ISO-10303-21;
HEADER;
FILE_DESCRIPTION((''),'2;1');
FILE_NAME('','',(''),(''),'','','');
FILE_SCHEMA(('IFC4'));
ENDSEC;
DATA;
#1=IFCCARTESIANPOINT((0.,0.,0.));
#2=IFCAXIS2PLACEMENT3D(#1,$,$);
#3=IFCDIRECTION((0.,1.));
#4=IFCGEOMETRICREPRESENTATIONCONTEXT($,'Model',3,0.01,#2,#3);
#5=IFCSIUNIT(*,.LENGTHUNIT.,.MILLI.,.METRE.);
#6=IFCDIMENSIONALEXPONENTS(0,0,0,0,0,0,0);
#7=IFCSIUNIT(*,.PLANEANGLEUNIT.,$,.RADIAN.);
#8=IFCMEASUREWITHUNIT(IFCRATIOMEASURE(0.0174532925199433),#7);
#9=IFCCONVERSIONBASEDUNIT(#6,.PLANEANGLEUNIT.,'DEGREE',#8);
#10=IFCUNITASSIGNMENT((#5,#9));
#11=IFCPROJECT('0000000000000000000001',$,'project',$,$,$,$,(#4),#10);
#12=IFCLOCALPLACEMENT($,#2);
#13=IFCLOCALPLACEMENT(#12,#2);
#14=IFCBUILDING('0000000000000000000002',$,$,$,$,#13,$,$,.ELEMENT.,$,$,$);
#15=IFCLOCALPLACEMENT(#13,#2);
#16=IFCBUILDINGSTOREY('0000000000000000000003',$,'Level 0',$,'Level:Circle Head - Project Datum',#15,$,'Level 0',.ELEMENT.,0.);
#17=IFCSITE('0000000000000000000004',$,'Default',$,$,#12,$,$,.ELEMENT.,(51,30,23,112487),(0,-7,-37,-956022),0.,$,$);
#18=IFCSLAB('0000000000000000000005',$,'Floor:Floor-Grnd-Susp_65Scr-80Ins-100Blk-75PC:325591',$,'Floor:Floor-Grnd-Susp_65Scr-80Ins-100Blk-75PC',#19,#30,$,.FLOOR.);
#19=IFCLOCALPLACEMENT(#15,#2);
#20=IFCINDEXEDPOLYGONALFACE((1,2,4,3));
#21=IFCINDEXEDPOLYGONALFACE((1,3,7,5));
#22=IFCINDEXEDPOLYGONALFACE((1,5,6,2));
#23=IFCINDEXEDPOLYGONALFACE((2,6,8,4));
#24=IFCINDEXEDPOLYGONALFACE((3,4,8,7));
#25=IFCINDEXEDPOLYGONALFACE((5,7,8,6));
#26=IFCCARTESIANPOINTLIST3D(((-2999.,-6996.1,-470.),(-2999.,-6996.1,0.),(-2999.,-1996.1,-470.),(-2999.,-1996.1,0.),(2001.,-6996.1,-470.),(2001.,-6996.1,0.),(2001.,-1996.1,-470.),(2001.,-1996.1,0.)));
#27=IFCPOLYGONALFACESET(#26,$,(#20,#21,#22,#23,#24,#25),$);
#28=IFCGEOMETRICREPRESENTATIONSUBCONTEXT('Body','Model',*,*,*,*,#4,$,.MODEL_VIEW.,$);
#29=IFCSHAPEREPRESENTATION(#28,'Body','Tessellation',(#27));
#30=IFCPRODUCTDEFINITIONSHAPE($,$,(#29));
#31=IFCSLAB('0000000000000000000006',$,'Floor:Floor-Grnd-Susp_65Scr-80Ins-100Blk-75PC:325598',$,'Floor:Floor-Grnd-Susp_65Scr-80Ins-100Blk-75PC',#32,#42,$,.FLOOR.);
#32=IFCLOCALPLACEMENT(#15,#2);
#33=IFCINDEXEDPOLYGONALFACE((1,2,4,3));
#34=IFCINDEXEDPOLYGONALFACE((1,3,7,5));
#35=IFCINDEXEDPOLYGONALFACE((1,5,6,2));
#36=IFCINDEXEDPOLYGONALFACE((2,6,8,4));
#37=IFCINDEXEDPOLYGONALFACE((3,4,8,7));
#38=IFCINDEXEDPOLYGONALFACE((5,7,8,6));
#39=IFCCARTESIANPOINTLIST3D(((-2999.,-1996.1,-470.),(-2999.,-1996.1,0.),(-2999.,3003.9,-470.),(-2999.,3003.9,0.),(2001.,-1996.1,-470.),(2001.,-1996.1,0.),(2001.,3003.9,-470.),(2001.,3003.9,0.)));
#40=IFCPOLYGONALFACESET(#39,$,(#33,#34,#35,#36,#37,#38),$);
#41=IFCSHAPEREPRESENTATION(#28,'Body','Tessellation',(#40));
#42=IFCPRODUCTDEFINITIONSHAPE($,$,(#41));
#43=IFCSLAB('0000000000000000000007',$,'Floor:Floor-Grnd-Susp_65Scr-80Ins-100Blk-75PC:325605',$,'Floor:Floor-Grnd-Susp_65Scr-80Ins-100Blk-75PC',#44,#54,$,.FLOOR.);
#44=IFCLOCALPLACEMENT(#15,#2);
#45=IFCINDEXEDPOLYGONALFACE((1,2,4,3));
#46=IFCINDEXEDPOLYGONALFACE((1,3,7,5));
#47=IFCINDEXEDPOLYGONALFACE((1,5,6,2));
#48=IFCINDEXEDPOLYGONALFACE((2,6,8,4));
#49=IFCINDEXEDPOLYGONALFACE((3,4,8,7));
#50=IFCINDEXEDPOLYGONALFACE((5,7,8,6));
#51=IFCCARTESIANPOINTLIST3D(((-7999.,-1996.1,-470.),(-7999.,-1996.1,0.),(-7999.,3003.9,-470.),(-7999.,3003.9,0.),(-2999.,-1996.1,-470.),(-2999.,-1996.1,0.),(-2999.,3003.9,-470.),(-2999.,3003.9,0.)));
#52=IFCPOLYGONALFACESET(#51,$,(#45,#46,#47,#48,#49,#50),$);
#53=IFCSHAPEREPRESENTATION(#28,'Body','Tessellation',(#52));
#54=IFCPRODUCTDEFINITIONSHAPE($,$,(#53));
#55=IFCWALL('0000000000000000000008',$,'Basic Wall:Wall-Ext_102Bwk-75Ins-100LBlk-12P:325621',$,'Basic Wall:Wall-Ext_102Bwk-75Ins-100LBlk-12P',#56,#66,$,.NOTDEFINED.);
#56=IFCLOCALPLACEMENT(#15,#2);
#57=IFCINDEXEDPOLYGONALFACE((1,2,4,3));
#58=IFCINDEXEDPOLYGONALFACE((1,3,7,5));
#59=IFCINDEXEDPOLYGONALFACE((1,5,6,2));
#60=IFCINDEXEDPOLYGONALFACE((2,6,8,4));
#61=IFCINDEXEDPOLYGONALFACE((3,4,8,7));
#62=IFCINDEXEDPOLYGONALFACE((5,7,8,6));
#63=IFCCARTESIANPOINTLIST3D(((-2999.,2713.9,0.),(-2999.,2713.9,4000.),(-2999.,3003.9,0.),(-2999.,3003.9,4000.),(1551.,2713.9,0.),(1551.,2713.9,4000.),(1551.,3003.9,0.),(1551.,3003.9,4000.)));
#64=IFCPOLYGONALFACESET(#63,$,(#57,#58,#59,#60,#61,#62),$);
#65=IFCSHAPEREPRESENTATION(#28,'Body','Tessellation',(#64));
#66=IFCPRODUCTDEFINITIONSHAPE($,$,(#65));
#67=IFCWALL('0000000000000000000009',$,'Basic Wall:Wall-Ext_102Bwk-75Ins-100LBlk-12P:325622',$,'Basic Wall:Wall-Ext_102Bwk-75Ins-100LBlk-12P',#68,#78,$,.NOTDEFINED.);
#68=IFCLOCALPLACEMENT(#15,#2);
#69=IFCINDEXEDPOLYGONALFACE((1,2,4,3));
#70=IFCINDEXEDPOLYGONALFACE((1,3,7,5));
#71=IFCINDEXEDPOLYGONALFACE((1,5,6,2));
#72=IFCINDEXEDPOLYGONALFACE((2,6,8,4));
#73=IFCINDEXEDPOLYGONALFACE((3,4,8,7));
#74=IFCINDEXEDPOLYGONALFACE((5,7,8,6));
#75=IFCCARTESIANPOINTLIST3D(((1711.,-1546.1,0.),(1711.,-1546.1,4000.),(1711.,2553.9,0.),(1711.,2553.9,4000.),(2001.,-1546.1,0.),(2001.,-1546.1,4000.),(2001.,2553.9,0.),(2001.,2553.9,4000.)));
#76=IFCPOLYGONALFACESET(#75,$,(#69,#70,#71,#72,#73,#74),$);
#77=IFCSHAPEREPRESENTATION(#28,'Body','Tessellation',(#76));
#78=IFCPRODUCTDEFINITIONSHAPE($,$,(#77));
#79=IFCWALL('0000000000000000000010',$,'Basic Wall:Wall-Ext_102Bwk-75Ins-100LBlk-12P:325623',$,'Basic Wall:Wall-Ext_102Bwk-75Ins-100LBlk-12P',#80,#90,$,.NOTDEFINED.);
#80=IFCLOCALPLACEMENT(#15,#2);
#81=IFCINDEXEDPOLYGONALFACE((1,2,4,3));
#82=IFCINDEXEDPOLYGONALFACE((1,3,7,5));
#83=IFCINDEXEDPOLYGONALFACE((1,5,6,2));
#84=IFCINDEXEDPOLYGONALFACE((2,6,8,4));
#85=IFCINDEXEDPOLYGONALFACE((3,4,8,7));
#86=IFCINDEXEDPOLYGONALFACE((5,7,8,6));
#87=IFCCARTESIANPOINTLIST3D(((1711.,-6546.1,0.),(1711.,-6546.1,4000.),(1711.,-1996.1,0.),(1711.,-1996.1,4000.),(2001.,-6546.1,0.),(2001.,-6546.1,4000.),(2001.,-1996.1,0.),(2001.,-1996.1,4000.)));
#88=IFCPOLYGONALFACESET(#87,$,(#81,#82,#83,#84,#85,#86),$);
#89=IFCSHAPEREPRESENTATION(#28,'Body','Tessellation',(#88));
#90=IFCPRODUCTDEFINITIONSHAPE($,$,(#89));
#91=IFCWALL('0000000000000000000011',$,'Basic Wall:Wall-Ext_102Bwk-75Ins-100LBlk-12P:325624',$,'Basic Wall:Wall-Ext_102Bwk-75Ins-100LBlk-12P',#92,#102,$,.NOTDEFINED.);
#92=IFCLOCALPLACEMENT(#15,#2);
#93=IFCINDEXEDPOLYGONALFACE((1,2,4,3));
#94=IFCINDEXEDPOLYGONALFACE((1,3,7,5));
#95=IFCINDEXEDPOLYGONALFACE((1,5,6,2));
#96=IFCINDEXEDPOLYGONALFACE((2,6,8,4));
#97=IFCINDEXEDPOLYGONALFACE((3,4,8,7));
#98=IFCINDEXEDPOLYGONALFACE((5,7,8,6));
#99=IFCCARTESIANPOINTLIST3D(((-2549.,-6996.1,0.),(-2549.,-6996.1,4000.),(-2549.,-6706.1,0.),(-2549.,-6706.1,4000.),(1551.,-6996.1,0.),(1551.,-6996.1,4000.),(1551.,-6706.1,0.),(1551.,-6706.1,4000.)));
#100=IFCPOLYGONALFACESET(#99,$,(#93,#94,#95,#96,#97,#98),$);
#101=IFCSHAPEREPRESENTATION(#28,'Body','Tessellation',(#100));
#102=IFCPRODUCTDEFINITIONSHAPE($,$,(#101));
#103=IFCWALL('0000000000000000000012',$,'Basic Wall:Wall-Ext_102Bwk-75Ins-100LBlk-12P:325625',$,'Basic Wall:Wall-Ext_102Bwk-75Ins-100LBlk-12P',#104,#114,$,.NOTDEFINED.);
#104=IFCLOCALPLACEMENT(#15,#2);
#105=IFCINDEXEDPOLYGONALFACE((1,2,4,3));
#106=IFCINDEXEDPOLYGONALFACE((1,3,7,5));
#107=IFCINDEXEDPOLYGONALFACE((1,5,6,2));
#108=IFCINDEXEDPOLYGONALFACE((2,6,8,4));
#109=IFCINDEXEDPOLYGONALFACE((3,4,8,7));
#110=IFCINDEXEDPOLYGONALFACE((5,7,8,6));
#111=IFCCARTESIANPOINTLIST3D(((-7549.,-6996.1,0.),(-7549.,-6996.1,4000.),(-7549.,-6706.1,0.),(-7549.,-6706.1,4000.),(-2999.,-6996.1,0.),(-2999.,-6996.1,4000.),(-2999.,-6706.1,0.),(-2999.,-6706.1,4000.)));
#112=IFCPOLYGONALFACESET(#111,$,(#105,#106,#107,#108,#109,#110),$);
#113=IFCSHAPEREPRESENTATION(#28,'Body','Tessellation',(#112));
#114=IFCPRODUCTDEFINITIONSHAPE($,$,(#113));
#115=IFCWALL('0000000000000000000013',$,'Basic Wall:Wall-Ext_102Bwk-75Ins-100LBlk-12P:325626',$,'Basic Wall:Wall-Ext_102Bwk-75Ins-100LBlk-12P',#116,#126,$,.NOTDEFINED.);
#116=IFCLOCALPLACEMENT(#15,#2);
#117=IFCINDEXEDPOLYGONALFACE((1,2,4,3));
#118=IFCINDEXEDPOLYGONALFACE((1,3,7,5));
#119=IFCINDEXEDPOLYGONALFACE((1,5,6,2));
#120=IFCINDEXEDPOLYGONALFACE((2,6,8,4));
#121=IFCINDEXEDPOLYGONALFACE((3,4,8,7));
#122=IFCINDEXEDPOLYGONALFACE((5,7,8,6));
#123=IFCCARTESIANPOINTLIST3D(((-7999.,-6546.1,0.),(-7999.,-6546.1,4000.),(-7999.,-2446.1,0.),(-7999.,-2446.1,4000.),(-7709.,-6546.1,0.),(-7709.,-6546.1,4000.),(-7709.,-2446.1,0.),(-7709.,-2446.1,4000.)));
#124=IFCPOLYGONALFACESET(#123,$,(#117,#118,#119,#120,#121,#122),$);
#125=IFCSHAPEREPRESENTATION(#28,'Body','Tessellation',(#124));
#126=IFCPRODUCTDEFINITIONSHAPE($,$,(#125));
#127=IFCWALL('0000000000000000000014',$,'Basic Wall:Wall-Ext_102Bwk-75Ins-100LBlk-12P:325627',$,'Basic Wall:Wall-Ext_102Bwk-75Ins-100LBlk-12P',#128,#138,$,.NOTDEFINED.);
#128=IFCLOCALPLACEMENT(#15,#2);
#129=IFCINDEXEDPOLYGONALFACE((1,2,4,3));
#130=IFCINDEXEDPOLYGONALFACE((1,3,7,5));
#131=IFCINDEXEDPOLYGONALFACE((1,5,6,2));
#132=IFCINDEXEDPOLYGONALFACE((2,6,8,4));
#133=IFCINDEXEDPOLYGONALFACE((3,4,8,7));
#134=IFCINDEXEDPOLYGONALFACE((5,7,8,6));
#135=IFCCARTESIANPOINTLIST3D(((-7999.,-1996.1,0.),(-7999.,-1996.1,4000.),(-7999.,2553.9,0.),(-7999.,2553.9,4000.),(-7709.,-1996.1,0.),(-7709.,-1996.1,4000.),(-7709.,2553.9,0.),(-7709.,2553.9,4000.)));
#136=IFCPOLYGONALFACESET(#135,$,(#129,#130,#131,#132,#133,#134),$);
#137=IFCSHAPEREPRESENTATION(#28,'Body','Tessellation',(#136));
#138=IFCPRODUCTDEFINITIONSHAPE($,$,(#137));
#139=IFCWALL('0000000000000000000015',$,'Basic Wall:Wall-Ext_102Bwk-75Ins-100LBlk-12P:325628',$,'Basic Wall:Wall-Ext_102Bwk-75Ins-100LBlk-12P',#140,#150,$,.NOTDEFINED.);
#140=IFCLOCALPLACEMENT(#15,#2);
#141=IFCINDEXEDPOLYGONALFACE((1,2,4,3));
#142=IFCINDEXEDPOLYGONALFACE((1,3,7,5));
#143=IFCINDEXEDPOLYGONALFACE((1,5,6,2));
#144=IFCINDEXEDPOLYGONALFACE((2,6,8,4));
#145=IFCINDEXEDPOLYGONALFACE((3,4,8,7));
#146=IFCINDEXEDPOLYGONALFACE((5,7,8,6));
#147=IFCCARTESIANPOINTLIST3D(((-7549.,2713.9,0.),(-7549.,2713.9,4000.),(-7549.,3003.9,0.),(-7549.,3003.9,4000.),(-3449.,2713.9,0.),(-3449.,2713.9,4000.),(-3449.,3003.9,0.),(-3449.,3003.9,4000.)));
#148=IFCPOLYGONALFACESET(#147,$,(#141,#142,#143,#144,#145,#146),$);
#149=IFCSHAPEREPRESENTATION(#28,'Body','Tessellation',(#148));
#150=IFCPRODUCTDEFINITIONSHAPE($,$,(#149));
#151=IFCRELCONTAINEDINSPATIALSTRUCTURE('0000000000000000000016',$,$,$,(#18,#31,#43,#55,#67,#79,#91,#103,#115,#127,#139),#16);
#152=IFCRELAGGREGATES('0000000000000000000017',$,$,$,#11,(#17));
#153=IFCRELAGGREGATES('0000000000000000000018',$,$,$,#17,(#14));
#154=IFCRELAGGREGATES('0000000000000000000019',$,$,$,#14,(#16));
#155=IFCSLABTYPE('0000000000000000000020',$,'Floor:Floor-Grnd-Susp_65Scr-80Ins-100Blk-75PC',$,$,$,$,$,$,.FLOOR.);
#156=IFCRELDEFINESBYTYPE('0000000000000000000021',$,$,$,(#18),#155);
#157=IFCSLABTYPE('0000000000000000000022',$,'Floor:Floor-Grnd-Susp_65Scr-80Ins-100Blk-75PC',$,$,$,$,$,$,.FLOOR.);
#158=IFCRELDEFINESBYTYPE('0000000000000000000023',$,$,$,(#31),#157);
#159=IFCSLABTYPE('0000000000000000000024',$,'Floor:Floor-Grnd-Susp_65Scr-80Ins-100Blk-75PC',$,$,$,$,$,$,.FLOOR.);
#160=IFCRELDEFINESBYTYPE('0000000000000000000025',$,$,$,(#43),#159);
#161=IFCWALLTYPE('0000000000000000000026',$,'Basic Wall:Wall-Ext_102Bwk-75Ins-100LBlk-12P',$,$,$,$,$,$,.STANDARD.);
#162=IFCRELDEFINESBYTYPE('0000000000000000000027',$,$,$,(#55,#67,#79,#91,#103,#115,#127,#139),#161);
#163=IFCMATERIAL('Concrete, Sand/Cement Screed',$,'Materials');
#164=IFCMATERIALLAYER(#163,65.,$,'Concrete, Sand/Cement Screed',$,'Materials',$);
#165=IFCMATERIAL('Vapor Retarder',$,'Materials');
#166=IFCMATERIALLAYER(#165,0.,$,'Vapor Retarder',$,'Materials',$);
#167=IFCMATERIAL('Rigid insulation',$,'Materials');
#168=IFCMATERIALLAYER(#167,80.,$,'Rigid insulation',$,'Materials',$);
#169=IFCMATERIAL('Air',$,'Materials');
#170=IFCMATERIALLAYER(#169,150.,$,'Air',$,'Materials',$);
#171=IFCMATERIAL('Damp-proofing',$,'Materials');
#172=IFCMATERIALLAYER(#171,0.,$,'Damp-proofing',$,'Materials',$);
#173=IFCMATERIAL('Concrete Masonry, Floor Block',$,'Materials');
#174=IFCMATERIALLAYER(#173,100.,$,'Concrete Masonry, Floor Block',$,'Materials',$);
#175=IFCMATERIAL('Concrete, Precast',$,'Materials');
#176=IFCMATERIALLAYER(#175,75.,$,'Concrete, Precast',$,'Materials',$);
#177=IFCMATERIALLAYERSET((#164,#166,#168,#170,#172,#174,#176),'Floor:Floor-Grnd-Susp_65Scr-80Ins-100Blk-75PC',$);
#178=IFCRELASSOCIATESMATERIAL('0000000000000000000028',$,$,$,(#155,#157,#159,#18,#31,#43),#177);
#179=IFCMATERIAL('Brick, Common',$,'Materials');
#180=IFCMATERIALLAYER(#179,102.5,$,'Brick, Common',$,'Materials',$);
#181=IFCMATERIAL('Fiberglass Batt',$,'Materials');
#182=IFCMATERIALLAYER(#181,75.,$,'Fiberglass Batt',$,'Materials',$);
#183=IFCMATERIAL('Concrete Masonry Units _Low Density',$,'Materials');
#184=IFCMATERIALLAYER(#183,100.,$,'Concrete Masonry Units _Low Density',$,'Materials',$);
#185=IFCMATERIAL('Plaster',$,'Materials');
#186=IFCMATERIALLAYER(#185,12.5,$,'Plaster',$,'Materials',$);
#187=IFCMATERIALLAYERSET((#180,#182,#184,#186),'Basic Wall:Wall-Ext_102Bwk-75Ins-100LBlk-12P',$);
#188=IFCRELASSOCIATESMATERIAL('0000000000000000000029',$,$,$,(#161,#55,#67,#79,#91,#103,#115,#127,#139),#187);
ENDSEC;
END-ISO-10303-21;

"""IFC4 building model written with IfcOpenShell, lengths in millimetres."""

from ifc_helpers import new_model, entity, si_unit, converted_unit, direction, frame, frame_2d, origin, origin_2d_with_axis, place, context, subcontext, project, spatial, rectangle, extrude, material, layer, layer_set, layer_usage, type_object, element, save


model = new_model("IFC4")

# Units and contexts
model_context = context("Model", 3, precision=0.01, world=origin(), true_north=direction((0.0, 1.0)))
body_context = subcontext(model_context, "Body", "Model", "MODEL_VIEW")
ifc_project = project(units=[si_unit("LENGTHUNIT", "METRE", prefix="MILLI"), converted_unit("PLANEANGLEUNIT", "DEGREE", entity("IfcRatioMeasure", 0.0174532925199433), si_unit("PLANEANGLEUNIT", "RADIAN"), dimensions=[0, 0, 0, 0, 0, 0, 0])], contexts=[model_context])

# Site, building, storey
site_placement = place(None, origin())
site = spatial("IfcSite", under=ifc_project, at=site_placement, Name="Default", CompositionType="ELEMENT", RefLatitude=(51, 30, 23, 112487), RefLongitude=(0, -7, -37, -956022), RefElevation=0.0)
building_placement = place(site_placement, origin())
building = spatial("IfcBuilding", under=site, at=building_placement, CompositionType="ELEMENT")
storey_placement = place(building_placement, origin())
storey = spatial("IfcBuildingStorey", under=building, at=storey_placement, Name="Level 0", ObjectType="Level:Circle Head - Project Datum", LongName="Level 0", CompositionType="ELEMENT", Elevation=0.0)

# Slabs
ifc_material_1 = material(Name="Concrete, Sand/Cement Screed", Category="Materials")
ifc_layer_1 = layer(ifc_material_1, 65.0, Name="Concrete, Sand/Cement Screed", Category="Materials")
ifc_material_2 = material(Name="Vapor Retarder", Category="Materials")
ifc_layer_2 = layer(ifc_material_2, 0.0, Name="Vapor Retarder", Category="Materials")
ifc_material_3 = material(Name="Rigid insulation", Category="Materials")
ifc_layer_3 = layer(ifc_material_3, 80.0, Name="Rigid insulation", Category="Materials")
ifc_material_4 = material(Name="Air", Category="Materials")
ifc_layer_4 = layer(ifc_material_4, 150.0, Name="Air", Category="Materials")
ifc_material_5 = material(Name="Damp-proofing", Category="Materials")
ifc_layer_5 = layer(ifc_material_5, 0.0, Name="Damp-proofing", Category="Materials")
ifc_material_6 = material(Name="Concrete Masonry, Floor Block", Category="Materials")
ifc_layer_6 = layer(ifc_material_6, 100.0, Name="Concrete Masonry, Floor Block", Category="Materials")
ifc_material_7 = material(Name="Concrete, Precast", Category="Materials")
ifc_layer_7 = layer(ifc_material_7, 75.0, Name="Concrete, Precast", Category="Materials")
ifc_layer_set_1 = layer_set([ifc_layer_1, ifc_layer_2, ifc_layer_3, ifc_layer_4, ifc_layer_5, ifc_layer_6, ifc_layer_7], Name="Floor:Floor-Grnd-Susp_65Scr-80Ins-100Blk-75PC")
ifc_layer_usage_1 = layer_usage(ifc_layer_set_1, "AXIS3", "POSITIVE", 0.0)
slab_type_1 = type_object("IfcSlabType", Name="Floor:Floor-Grnd-Susp_65Scr-80Ins-100Blk-75PC", PredefinedType="FLOOR", material=ifc_layer_set_1)
slab_1_placement = place(storey_placement, origin())
element("IfcSlab", 1, at=slab_1_placement, inside=storey, type_object=slab_type_1, material=ifc_layer_usage_1, Name="Floor:Floor-Grnd-Susp_65Scr-80Ins-100Blk-75PC:325591", ObjectType="Floor:Floor-Grnd-Susp_65Scr-80Ins-100Blk-75PC", PredefinedType="FLOOR", context=body_context, shape_type="SweptSolid", body=[
    extrude(rectangle(XDim=5000.0, YDim=5000.0, at=frame_2d((0.0, 0.0), x_axis=(1.0, 0.0))), frame((-499.0, -4496.1, 0.0), z_axis=(0.0, 0.0, -1.0), x_axis=(0.0, 1.0, 0.0)), (0.0, 0.0, 1.0), 470.0),
])
ifc_layer_usage_2 = layer_usage(ifc_layer_set_1, "AXIS3", "POSITIVE", 0.0)
slab_type_2 = type_object("IfcSlabType", Name="Floor:Floor-Grnd-Susp_65Scr-80Ins-100Blk-75PC", PredefinedType="FLOOR", material=ifc_layer_set_1)
slab_2_placement = place(storey_placement, origin())
element("IfcSlab", 2, at=slab_2_placement, inside=storey, type_object=slab_type_2, material=ifc_layer_usage_2, Name="Floor:Floor-Grnd-Susp_65Scr-80Ins-100Blk-75PC:325598", ObjectType="Floor:Floor-Grnd-Susp_65Scr-80Ins-100Blk-75PC", PredefinedType="FLOOR", context=body_context, shape_type="SweptSolid", body=[
    extrude(rectangle(XDim=5000.0, YDim=5000.0, at=origin_2d_with_axis()), frame((-499.0, 503.9, 0.0), z_axis=(0.0, 0.0, -1.0), x_axis=(0.0, 1.0, 0.0)), (0.0, 0.0, 1.0), 470.0),
])
ifc_layer_usage_3 = layer_usage(ifc_layer_set_1, "AXIS3", "POSITIVE", 0.0)
slab_type_3 = type_object("IfcSlabType", Name="Floor:Floor-Grnd-Susp_65Scr-80Ins-100Blk-75PC", PredefinedType="FLOOR", material=ifc_layer_set_1)
slab_3_placement = place(storey_placement, origin())
element("IfcSlab", 3, at=slab_3_placement, inside=storey, type_object=slab_type_3, material=ifc_layer_usage_3, Name="Floor:Floor-Grnd-Susp_65Scr-80Ins-100Blk-75PC:325605", ObjectType="Floor:Floor-Grnd-Susp_65Scr-80Ins-100Blk-75PC", PredefinedType="FLOOR", context=body_context, shape_type="SweptSolid", body=[
    extrude(rectangle(XDim=5000.0, YDim=5000.0, at=origin_2d_with_axis()), frame((-5499.0, 503.9, 0.0), z_axis=(0.0, 0.0, -1.0), x_axis=(0.0, 1.0, 0.0)), (0.0, 0.0, 1.0), 470.0),
])

# Walls
ifc_material_8 = material(Name="Brick, Common", Category="Materials")
ifc_layer_8 = layer(ifc_material_8, 102.5, Name="Brick, Common", Category="Materials")
ifc_material_9 = material(Name="Fiberglass Batt", Category="Materials")
ifc_layer_9 = layer(ifc_material_9, 75.0, Name="Fiberglass Batt", Category="Materials")
ifc_material_10 = material(Name="Concrete Masonry Units _Low Density", Category="Materials")
ifc_layer_10 = layer(ifc_material_10, 100.0, Name="Concrete Masonry Units _Low Density", Category="Materials")
ifc_material_11 = material(Name="Plaster", Category="Materials")
ifc_layer_11 = layer(ifc_material_11, 12.5, Name="Plaster", Category="Materials")
ifc_layer_set_2 = layer_set([ifc_layer_8, ifc_layer_9, ifc_layer_10, ifc_layer_11], Name="Basic Wall:Wall-Ext_102Bwk-75Ins-100LBlk-12P")
ifc_layer_usage_4 = layer_usage(ifc_layer_set_2, "AXIS2", "NEGATIVE", 145.0)
wall_type = type_object("IfcWallType", Name="Basic Wall:Wall-Ext_102Bwk-75Ins-100LBlk-12P", PredefinedType="STANDARD", material=ifc_layer_set_2)
wall_1_placement = place(storey_placement, frame((-2999.0, 2858.9, 0.0)))
element("IfcWall", 4, at=wall_1_placement, inside=storey, type_object=wall_type, material=ifc_layer_usage_4, Name="Basic Wall:Wall-Ext_102Bwk-75Ins-100LBlk-12P:325621", ObjectType="Basic Wall:Wall-Ext_102Bwk-75Ins-100LBlk-12P", PredefinedType="NOTDEFINED", context=body_context, shape_type="SweptSolid", body=[
    extrude(rectangle(XDim=4550.0, YDim=290.0, at=frame_2d((2275.0, 0.0), x_axis=(-1.0, 0.0))), origin(), (0.0, 0.0, 1.0), 4000.0),
])
ifc_layer_usage_5 = layer_usage(ifc_layer_set_2, "AXIS2", "NEGATIVE", 145.0)
wall_2_placement = place(storey_placement, frame((1856.0, 2553.9, 0.0), z_axis=(0.0, 0.0, 1.0), x_axis=(0.0, -1.0, 0.0)))
element("IfcWall", 5, at=wall_2_placement, inside=storey, type_object=wall_type, material=ifc_layer_usage_5, Name="Basic Wall:Wall-Ext_102Bwk-75Ins-100LBlk-12P:325622", ObjectType="Basic Wall:Wall-Ext_102Bwk-75Ins-100LBlk-12P", PredefinedType="NOTDEFINED", context=body_context, shape_type="SweptSolid", body=[
    extrude(rectangle(XDim=4100.0, YDim=290.0, at=frame_2d((2050.0, 0.0), x_axis=(-1.0, 0.0))), origin(), (0.0, 0.0, 1.0), 4000.0),
])
ifc_layer_usage_6 = layer_usage(ifc_layer_set_2, "AXIS2", "NEGATIVE", 145.0)
wall_3_placement = place(storey_placement, frame((1856.0, -1996.1, 0.0), z_axis=(0.0, 0.0, 1.0), x_axis=(0.0, -1.0, 0.0)))
element("IfcWall", 6, at=wall_3_placement, inside=storey, type_object=wall_type, material=ifc_layer_usage_6, Name="Basic Wall:Wall-Ext_102Bwk-75Ins-100LBlk-12P:325623", ObjectType="Basic Wall:Wall-Ext_102Bwk-75Ins-100LBlk-12P", PredefinedType="NOTDEFINED", context=body_context, shape_type="SweptSolid", body=[
    extrude(rectangle(XDim=4550.0, YDim=290.0, at=frame_2d((2275.0, 0.0), x_axis=(-1.0, 0.0))), origin(), (0.0, 0.0, 1.0), 4000.0),
])
ifc_layer_usage_7 = layer_usage(ifc_layer_set_2, "AXIS2", "NEGATIVE", 145.0)
wall_4_placement = place(storey_placement, frame((1551.0, -6851.1, 0.0), z_axis=(0.0, 0.0, 1.0), x_axis=(-1.0, 0.0, 0.0)))
element("IfcWall", 7, at=wall_4_placement, inside=storey, type_object=wall_type, material=ifc_layer_usage_7, Name="Basic Wall:Wall-Ext_102Bwk-75Ins-100LBlk-12P:325624", ObjectType="Basic Wall:Wall-Ext_102Bwk-75Ins-100LBlk-12P", PredefinedType="NOTDEFINED", context=body_context, shape_type="SweptSolid", body=[
    extrude(rectangle(XDim=4100.0, YDim=290.0, at=frame_2d((2050.0, 0.0), x_axis=(-1.0, 0.0))), origin(), (0.0, 0.0, 1.0), 4000.0),
])
ifc_layer_usage_8 = layer_usage(ifc_layer_set_2, "AXIS2", "NEGATIVE", 145.0)
wall_5_placement = place(storey_placement, frame((-2999.0, -6851.1, 0.0), z_axis=(0.0, 0.0, 1.0), x_axis=(-1.0, 0.0, 0.0)))
element("IfcWall", 8, at=wall_5_placement, inside=storey, type_object=wall_type, material=ifc_layer_usage_8, Name="Basic Wall:Wall-Ext_102Bwk-75Ins-100LBlk-12P:325625", ObjectType="Basic Wall:Wall-Ext_102Bwk-75Ins-100LBlk-12P", PredefinedType="NOTDEFINED", context=body_context, shape_type="SweptSolid", body=[
    extrude(rectangle(XDim=4550.0, YDim=290.0, at=frame_2d((2275.0, 0.0), x_axis=(-1.0, 0.0))), origin(), (0.0, 0.0, 1.0), 4000.0),
])
ifc_layer_usage_9 = layer_usage(ifc_layer_set_2, "AXIS2", "NEGATIVE", 145.0)
wall_6_placement = place(storey_placement, frame((-7854.0, -6546.1, 0.0), z_axis=(0.0, 0.0, 1.0), x_axis=(0.0, 1.0, 0.0)))
element("IfcWall", 9, at=wall_6_placement, inside=storey, type_object=wall_type, material=ifc_layer_usage_9, Name="Basic Wall:Wall-Ext_102Bwk-75Ins-100LBlk-12P:325626", ObjectType="Basic Wall:Wall-Ext_102Bwk-75Ins-100LBlk-12P", PredefinedType="NOTDEFINED", context=body_context, shape_type="SweptSolid", body=[
    extrude(rectangle(XDim=4100.0, YDim=290.0, at=frame_2d((2050.0, 0.0), x_axis=(-1.0, 0.0))), origin(), (0.0, 0.0, 1.0), 4000.0),
])
ifc_layer_usage_10 = layer_usage(ifc_layer_set_2, "AXIS2", "NEGATIVE", 145.0)
wall_7_placement = place(storey_placement, frame((-7854.0, -1996.1, 0.0), z_axis=(0.0, 0.0, 1.0), x_axis=(0.0, 1.0, 0.0)))
element("IfcWall", 10, at=wall_7_placement, inside=storey, type_object=wall_type, material=ifc_layer_usage_10, Name="Basic Wall:Wall-Ext_102Bwk-75Ins-100LBlk-12P:325627", ObjectType="Basic Wall:Wall-Ext_102Bwk-75Ins-100LBlk-12P", PredefinedType="NOTDEFINED", context=body_context, shape_type="SweptSolid", body=[
    extrude(rectangle(XDim=4550.0, YDim=290.0, at=frame_2d((2275.0, 0.0), x_axis=(-1.0, 0.0))), origin(), (0.0, 0.0, 1.0), 4000.0),
])
ifc_layer_usage_11 = layer_usage(ifc_layer_set_2, "AXIS2", "NEGATIVE", 145.0)
wall_8_placement = place(storey_placement, frame((-7549.0, 2858.9, 0.0)))
element("IfcWall", 11, at=wall_8_placement, inside=storey, type_object=wall_type, material=ifc_layer_usage_11, Name="Basic Wall:Wall-Ext_102Bwk-75Ins-100LBlk-12P:325628", ObjectType="Basic Wall:Wall-Ext_102Bwk-75Ins-100LBlk-12P", PredefinedType="NOTDEFINED", context=body_context, shape_type="SweptSolid", body=[
    extrude(rectangle(XDim=4100.0, YDim=290.0, at=frame_2d((2050.0, 0.0), x_axis=(-1.0, 0.0))), origin(), (0.0, 0.0, 1.0), 4000.0),
])

save(model, "model.ifc")
